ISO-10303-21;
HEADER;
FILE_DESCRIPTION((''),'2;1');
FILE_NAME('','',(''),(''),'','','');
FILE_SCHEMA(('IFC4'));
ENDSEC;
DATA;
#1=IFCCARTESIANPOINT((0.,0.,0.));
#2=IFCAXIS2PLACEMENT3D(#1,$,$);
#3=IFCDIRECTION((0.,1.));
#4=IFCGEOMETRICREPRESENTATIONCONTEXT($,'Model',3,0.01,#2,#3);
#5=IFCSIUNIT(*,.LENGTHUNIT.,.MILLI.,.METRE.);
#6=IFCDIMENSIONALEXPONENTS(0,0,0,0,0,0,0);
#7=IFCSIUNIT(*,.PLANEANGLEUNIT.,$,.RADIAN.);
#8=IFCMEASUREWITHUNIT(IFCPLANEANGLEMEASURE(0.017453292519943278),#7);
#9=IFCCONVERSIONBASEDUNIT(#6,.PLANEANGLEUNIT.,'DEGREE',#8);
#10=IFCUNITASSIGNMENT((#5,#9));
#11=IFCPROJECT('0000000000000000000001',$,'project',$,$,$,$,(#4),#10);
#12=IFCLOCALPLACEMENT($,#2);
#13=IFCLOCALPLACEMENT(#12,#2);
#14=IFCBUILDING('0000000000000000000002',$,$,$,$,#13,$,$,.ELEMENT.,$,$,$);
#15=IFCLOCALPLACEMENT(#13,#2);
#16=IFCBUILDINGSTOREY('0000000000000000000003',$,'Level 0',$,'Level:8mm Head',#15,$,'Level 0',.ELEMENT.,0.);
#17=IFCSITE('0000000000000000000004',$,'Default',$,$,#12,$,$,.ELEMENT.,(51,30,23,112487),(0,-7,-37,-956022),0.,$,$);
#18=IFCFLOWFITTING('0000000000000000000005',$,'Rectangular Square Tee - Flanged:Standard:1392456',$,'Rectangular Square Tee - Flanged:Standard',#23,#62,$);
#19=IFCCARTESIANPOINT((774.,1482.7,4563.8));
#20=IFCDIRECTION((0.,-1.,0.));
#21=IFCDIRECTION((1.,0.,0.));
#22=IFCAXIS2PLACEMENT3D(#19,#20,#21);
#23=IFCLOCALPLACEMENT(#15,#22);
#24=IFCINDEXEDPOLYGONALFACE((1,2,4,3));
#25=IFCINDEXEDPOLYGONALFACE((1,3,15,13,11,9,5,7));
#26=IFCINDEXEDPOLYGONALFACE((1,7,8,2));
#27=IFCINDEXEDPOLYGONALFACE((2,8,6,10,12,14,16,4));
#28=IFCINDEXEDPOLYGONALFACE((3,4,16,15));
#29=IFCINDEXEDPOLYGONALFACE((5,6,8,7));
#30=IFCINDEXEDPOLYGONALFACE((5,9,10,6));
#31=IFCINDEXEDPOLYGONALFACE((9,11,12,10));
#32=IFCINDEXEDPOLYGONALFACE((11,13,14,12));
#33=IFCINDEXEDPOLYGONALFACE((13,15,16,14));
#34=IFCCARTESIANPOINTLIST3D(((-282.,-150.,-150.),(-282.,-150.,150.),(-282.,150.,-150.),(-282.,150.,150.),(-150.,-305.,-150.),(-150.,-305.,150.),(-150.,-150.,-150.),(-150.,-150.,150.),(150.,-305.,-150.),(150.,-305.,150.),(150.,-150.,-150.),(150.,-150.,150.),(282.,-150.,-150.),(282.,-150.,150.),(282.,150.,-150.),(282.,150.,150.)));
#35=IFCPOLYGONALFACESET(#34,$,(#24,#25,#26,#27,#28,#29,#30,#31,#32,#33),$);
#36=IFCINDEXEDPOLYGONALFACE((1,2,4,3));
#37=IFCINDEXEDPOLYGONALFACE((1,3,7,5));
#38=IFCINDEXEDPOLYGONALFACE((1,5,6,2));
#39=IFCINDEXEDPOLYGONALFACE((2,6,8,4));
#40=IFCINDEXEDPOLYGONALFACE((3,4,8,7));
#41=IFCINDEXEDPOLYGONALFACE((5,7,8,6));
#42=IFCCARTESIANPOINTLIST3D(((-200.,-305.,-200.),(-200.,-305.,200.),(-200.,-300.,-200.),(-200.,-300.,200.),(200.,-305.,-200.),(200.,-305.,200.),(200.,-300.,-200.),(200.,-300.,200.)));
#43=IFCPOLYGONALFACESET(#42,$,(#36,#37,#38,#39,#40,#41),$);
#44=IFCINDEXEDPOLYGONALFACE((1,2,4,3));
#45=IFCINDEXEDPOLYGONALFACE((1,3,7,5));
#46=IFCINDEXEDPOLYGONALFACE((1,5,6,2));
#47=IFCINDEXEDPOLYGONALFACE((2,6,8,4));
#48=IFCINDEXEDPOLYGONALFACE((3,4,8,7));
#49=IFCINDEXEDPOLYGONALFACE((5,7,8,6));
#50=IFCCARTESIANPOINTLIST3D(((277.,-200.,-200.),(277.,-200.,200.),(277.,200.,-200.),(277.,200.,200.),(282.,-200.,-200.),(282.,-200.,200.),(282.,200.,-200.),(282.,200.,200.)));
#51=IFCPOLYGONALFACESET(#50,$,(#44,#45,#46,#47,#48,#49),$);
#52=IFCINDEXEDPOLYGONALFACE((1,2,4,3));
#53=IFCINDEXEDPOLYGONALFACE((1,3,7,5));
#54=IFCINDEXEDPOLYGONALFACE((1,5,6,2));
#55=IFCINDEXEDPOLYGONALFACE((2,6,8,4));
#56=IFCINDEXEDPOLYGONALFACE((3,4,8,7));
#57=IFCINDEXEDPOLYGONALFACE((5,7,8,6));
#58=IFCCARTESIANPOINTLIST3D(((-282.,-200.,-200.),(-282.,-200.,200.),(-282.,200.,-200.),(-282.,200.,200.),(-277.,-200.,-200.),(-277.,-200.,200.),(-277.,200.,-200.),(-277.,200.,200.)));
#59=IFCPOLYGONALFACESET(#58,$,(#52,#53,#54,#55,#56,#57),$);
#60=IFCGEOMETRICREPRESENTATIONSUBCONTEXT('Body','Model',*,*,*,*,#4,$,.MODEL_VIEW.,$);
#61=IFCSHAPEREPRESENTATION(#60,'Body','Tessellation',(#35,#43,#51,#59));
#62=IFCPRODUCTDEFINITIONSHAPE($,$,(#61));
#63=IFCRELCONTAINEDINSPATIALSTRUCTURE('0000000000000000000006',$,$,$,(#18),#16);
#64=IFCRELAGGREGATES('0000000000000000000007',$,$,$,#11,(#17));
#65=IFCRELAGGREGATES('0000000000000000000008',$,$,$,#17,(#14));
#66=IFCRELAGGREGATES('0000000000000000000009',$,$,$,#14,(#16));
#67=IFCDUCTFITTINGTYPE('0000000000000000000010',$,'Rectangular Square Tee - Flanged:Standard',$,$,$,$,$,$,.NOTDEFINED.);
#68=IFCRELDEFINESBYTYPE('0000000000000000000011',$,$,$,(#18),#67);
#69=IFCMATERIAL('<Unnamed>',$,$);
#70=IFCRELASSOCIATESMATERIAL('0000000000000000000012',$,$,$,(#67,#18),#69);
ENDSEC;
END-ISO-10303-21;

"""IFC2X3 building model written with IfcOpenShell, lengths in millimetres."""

from ifc_helpers import new_model, entity, si_unit, converted_unit, direction, frame, frame_2d, origin, origin_2d_with_axis, place, context, subcontext, project, spatial, polyline, rectangle, outline, extrude, source, transform, mapped, material, type_object, type_shapes, element, save


model = new_model("IFC2X3")

# Units and contexts
model_context = context("Model", 3, precision=0.01, world=origin(), true_north=direction((0.0, 1.0)))
body_context = subcontext(model_context, "Body", "Model", "MODEL_VIEW")
ifc_project = project(units=[si_unit("LENGTHUNIT", "METRE", prefix="MILLI"), converted_unit("PLANEANGLEUNIT", "DEGREE", entity("IfcPlaneAngleMeasure", 0.017453292519943278), si_unit("PLANEANGLEUNIT", "RADIAN"), dimensions=[0, 0, 0, 0, 0, 0, 0])], contexts=[model_context])

# Site, building, storey
site_placement = place(None, origin())
site = spatial("IfcSite", under=ifc_project, at=site_placement, Name="Default", CompositionType="ELEMENT", RefLatitude=(51, 30, 23, 112487), RefLongitude=(0, -7, -37, -956022), RefElevation=0.0)
building_placement = place(site_placement, origin())
building = spatial("IfcBuilding", under=site, at=building_placement, CompositionType="ELEMENT")
storey_placement = place(building_placement, origin())
storey = spatial("IfcBuildingStorey", under=building, at=storey_placement, Name="Level 0", ObjectType="Level:8mm Head", LongName="Level 0", CompositionType="ELEMENT", Elevation=0.0)

# Shared definitions
ifc_material_1 = material(Name="<Unnamed>")

# Flow fitting
duct_fitting_type_1 = type_object("IfcDuctFittingType", Name="Rectangular Square Tee - Flanged:Standard", PredefinedType="NOTDEFINED", material=ifc_material_1)
shared_shape_1 = source(origin(), body_context, "Body", "SweptSolid", [
    extrude(outline(polyline([(-282.0, 36.2), (-282.0, -263.8), (282.0, -263.7), (282.0, 36.3), (150.0, 36.3), (150.0, 191.2), (-150.0, 191.2), (-150.0, 36.2), (-282.0, 36.2)])), frame((0.0, -113.8, -150.0), z_axis=(0.0, 0.0, -1.0), x_axis=(1.0, 0.0, 0.0)), (0.0, 0.0, -1.0), 300.0),
    extrude(rectangle(XDim=5.0, YDim=400.0, at=frame_2d((0.0, 0.0), x_axis=(1.0, 0.0))), frame((0.0, -302.5, -200.0), z_axis=(0.0, 0.0, 1.0), x_axis=(0.0, -1.0, 0.0)), (0.0, 0.0, 1.0), 400.0),
    extrude(rectangle(XDim=5.0, YDim=400.0, at=origin_2d_with_axis()), frame((279.5, 0.0, -200.0)), (0.0, 0.0, 1.0), 400.0),
    extrude(rectangle(XDim=5.0, YDim=400.0, at=origin_2d_with_axis()), frame((-279.5, 0.0, -200.0)), (0.0, 0.0, 1.0), 400.0),
])
type_shapes(duct_fitting_type_1, [shared_shape_1])
flow_fitting_1_placement = place(storey_placement, frame((774.0, 1482.7, 4563.8), z_axis=(0.0, -1.0, 0.0), x_axis=(1.0, 0.0, 0.0)))
element("IfcFlowFitting", 1, at=flow_fitting_1_placement, inside=storey, type_object=duct_fitting_type_1, material=ifc_material_1, Name="Rectangular Square Tee - Flanged:Standard:1392456", ObjectType="Rectangular Square Tee - Flanged:Standard", context=body_context, shape_type="MappedRepresentation", body=[
    mapped(shared_shape_1, transform((0.0, 0.0, 0.0), scale=1.0)),
])

save(model, "model.ifc")
